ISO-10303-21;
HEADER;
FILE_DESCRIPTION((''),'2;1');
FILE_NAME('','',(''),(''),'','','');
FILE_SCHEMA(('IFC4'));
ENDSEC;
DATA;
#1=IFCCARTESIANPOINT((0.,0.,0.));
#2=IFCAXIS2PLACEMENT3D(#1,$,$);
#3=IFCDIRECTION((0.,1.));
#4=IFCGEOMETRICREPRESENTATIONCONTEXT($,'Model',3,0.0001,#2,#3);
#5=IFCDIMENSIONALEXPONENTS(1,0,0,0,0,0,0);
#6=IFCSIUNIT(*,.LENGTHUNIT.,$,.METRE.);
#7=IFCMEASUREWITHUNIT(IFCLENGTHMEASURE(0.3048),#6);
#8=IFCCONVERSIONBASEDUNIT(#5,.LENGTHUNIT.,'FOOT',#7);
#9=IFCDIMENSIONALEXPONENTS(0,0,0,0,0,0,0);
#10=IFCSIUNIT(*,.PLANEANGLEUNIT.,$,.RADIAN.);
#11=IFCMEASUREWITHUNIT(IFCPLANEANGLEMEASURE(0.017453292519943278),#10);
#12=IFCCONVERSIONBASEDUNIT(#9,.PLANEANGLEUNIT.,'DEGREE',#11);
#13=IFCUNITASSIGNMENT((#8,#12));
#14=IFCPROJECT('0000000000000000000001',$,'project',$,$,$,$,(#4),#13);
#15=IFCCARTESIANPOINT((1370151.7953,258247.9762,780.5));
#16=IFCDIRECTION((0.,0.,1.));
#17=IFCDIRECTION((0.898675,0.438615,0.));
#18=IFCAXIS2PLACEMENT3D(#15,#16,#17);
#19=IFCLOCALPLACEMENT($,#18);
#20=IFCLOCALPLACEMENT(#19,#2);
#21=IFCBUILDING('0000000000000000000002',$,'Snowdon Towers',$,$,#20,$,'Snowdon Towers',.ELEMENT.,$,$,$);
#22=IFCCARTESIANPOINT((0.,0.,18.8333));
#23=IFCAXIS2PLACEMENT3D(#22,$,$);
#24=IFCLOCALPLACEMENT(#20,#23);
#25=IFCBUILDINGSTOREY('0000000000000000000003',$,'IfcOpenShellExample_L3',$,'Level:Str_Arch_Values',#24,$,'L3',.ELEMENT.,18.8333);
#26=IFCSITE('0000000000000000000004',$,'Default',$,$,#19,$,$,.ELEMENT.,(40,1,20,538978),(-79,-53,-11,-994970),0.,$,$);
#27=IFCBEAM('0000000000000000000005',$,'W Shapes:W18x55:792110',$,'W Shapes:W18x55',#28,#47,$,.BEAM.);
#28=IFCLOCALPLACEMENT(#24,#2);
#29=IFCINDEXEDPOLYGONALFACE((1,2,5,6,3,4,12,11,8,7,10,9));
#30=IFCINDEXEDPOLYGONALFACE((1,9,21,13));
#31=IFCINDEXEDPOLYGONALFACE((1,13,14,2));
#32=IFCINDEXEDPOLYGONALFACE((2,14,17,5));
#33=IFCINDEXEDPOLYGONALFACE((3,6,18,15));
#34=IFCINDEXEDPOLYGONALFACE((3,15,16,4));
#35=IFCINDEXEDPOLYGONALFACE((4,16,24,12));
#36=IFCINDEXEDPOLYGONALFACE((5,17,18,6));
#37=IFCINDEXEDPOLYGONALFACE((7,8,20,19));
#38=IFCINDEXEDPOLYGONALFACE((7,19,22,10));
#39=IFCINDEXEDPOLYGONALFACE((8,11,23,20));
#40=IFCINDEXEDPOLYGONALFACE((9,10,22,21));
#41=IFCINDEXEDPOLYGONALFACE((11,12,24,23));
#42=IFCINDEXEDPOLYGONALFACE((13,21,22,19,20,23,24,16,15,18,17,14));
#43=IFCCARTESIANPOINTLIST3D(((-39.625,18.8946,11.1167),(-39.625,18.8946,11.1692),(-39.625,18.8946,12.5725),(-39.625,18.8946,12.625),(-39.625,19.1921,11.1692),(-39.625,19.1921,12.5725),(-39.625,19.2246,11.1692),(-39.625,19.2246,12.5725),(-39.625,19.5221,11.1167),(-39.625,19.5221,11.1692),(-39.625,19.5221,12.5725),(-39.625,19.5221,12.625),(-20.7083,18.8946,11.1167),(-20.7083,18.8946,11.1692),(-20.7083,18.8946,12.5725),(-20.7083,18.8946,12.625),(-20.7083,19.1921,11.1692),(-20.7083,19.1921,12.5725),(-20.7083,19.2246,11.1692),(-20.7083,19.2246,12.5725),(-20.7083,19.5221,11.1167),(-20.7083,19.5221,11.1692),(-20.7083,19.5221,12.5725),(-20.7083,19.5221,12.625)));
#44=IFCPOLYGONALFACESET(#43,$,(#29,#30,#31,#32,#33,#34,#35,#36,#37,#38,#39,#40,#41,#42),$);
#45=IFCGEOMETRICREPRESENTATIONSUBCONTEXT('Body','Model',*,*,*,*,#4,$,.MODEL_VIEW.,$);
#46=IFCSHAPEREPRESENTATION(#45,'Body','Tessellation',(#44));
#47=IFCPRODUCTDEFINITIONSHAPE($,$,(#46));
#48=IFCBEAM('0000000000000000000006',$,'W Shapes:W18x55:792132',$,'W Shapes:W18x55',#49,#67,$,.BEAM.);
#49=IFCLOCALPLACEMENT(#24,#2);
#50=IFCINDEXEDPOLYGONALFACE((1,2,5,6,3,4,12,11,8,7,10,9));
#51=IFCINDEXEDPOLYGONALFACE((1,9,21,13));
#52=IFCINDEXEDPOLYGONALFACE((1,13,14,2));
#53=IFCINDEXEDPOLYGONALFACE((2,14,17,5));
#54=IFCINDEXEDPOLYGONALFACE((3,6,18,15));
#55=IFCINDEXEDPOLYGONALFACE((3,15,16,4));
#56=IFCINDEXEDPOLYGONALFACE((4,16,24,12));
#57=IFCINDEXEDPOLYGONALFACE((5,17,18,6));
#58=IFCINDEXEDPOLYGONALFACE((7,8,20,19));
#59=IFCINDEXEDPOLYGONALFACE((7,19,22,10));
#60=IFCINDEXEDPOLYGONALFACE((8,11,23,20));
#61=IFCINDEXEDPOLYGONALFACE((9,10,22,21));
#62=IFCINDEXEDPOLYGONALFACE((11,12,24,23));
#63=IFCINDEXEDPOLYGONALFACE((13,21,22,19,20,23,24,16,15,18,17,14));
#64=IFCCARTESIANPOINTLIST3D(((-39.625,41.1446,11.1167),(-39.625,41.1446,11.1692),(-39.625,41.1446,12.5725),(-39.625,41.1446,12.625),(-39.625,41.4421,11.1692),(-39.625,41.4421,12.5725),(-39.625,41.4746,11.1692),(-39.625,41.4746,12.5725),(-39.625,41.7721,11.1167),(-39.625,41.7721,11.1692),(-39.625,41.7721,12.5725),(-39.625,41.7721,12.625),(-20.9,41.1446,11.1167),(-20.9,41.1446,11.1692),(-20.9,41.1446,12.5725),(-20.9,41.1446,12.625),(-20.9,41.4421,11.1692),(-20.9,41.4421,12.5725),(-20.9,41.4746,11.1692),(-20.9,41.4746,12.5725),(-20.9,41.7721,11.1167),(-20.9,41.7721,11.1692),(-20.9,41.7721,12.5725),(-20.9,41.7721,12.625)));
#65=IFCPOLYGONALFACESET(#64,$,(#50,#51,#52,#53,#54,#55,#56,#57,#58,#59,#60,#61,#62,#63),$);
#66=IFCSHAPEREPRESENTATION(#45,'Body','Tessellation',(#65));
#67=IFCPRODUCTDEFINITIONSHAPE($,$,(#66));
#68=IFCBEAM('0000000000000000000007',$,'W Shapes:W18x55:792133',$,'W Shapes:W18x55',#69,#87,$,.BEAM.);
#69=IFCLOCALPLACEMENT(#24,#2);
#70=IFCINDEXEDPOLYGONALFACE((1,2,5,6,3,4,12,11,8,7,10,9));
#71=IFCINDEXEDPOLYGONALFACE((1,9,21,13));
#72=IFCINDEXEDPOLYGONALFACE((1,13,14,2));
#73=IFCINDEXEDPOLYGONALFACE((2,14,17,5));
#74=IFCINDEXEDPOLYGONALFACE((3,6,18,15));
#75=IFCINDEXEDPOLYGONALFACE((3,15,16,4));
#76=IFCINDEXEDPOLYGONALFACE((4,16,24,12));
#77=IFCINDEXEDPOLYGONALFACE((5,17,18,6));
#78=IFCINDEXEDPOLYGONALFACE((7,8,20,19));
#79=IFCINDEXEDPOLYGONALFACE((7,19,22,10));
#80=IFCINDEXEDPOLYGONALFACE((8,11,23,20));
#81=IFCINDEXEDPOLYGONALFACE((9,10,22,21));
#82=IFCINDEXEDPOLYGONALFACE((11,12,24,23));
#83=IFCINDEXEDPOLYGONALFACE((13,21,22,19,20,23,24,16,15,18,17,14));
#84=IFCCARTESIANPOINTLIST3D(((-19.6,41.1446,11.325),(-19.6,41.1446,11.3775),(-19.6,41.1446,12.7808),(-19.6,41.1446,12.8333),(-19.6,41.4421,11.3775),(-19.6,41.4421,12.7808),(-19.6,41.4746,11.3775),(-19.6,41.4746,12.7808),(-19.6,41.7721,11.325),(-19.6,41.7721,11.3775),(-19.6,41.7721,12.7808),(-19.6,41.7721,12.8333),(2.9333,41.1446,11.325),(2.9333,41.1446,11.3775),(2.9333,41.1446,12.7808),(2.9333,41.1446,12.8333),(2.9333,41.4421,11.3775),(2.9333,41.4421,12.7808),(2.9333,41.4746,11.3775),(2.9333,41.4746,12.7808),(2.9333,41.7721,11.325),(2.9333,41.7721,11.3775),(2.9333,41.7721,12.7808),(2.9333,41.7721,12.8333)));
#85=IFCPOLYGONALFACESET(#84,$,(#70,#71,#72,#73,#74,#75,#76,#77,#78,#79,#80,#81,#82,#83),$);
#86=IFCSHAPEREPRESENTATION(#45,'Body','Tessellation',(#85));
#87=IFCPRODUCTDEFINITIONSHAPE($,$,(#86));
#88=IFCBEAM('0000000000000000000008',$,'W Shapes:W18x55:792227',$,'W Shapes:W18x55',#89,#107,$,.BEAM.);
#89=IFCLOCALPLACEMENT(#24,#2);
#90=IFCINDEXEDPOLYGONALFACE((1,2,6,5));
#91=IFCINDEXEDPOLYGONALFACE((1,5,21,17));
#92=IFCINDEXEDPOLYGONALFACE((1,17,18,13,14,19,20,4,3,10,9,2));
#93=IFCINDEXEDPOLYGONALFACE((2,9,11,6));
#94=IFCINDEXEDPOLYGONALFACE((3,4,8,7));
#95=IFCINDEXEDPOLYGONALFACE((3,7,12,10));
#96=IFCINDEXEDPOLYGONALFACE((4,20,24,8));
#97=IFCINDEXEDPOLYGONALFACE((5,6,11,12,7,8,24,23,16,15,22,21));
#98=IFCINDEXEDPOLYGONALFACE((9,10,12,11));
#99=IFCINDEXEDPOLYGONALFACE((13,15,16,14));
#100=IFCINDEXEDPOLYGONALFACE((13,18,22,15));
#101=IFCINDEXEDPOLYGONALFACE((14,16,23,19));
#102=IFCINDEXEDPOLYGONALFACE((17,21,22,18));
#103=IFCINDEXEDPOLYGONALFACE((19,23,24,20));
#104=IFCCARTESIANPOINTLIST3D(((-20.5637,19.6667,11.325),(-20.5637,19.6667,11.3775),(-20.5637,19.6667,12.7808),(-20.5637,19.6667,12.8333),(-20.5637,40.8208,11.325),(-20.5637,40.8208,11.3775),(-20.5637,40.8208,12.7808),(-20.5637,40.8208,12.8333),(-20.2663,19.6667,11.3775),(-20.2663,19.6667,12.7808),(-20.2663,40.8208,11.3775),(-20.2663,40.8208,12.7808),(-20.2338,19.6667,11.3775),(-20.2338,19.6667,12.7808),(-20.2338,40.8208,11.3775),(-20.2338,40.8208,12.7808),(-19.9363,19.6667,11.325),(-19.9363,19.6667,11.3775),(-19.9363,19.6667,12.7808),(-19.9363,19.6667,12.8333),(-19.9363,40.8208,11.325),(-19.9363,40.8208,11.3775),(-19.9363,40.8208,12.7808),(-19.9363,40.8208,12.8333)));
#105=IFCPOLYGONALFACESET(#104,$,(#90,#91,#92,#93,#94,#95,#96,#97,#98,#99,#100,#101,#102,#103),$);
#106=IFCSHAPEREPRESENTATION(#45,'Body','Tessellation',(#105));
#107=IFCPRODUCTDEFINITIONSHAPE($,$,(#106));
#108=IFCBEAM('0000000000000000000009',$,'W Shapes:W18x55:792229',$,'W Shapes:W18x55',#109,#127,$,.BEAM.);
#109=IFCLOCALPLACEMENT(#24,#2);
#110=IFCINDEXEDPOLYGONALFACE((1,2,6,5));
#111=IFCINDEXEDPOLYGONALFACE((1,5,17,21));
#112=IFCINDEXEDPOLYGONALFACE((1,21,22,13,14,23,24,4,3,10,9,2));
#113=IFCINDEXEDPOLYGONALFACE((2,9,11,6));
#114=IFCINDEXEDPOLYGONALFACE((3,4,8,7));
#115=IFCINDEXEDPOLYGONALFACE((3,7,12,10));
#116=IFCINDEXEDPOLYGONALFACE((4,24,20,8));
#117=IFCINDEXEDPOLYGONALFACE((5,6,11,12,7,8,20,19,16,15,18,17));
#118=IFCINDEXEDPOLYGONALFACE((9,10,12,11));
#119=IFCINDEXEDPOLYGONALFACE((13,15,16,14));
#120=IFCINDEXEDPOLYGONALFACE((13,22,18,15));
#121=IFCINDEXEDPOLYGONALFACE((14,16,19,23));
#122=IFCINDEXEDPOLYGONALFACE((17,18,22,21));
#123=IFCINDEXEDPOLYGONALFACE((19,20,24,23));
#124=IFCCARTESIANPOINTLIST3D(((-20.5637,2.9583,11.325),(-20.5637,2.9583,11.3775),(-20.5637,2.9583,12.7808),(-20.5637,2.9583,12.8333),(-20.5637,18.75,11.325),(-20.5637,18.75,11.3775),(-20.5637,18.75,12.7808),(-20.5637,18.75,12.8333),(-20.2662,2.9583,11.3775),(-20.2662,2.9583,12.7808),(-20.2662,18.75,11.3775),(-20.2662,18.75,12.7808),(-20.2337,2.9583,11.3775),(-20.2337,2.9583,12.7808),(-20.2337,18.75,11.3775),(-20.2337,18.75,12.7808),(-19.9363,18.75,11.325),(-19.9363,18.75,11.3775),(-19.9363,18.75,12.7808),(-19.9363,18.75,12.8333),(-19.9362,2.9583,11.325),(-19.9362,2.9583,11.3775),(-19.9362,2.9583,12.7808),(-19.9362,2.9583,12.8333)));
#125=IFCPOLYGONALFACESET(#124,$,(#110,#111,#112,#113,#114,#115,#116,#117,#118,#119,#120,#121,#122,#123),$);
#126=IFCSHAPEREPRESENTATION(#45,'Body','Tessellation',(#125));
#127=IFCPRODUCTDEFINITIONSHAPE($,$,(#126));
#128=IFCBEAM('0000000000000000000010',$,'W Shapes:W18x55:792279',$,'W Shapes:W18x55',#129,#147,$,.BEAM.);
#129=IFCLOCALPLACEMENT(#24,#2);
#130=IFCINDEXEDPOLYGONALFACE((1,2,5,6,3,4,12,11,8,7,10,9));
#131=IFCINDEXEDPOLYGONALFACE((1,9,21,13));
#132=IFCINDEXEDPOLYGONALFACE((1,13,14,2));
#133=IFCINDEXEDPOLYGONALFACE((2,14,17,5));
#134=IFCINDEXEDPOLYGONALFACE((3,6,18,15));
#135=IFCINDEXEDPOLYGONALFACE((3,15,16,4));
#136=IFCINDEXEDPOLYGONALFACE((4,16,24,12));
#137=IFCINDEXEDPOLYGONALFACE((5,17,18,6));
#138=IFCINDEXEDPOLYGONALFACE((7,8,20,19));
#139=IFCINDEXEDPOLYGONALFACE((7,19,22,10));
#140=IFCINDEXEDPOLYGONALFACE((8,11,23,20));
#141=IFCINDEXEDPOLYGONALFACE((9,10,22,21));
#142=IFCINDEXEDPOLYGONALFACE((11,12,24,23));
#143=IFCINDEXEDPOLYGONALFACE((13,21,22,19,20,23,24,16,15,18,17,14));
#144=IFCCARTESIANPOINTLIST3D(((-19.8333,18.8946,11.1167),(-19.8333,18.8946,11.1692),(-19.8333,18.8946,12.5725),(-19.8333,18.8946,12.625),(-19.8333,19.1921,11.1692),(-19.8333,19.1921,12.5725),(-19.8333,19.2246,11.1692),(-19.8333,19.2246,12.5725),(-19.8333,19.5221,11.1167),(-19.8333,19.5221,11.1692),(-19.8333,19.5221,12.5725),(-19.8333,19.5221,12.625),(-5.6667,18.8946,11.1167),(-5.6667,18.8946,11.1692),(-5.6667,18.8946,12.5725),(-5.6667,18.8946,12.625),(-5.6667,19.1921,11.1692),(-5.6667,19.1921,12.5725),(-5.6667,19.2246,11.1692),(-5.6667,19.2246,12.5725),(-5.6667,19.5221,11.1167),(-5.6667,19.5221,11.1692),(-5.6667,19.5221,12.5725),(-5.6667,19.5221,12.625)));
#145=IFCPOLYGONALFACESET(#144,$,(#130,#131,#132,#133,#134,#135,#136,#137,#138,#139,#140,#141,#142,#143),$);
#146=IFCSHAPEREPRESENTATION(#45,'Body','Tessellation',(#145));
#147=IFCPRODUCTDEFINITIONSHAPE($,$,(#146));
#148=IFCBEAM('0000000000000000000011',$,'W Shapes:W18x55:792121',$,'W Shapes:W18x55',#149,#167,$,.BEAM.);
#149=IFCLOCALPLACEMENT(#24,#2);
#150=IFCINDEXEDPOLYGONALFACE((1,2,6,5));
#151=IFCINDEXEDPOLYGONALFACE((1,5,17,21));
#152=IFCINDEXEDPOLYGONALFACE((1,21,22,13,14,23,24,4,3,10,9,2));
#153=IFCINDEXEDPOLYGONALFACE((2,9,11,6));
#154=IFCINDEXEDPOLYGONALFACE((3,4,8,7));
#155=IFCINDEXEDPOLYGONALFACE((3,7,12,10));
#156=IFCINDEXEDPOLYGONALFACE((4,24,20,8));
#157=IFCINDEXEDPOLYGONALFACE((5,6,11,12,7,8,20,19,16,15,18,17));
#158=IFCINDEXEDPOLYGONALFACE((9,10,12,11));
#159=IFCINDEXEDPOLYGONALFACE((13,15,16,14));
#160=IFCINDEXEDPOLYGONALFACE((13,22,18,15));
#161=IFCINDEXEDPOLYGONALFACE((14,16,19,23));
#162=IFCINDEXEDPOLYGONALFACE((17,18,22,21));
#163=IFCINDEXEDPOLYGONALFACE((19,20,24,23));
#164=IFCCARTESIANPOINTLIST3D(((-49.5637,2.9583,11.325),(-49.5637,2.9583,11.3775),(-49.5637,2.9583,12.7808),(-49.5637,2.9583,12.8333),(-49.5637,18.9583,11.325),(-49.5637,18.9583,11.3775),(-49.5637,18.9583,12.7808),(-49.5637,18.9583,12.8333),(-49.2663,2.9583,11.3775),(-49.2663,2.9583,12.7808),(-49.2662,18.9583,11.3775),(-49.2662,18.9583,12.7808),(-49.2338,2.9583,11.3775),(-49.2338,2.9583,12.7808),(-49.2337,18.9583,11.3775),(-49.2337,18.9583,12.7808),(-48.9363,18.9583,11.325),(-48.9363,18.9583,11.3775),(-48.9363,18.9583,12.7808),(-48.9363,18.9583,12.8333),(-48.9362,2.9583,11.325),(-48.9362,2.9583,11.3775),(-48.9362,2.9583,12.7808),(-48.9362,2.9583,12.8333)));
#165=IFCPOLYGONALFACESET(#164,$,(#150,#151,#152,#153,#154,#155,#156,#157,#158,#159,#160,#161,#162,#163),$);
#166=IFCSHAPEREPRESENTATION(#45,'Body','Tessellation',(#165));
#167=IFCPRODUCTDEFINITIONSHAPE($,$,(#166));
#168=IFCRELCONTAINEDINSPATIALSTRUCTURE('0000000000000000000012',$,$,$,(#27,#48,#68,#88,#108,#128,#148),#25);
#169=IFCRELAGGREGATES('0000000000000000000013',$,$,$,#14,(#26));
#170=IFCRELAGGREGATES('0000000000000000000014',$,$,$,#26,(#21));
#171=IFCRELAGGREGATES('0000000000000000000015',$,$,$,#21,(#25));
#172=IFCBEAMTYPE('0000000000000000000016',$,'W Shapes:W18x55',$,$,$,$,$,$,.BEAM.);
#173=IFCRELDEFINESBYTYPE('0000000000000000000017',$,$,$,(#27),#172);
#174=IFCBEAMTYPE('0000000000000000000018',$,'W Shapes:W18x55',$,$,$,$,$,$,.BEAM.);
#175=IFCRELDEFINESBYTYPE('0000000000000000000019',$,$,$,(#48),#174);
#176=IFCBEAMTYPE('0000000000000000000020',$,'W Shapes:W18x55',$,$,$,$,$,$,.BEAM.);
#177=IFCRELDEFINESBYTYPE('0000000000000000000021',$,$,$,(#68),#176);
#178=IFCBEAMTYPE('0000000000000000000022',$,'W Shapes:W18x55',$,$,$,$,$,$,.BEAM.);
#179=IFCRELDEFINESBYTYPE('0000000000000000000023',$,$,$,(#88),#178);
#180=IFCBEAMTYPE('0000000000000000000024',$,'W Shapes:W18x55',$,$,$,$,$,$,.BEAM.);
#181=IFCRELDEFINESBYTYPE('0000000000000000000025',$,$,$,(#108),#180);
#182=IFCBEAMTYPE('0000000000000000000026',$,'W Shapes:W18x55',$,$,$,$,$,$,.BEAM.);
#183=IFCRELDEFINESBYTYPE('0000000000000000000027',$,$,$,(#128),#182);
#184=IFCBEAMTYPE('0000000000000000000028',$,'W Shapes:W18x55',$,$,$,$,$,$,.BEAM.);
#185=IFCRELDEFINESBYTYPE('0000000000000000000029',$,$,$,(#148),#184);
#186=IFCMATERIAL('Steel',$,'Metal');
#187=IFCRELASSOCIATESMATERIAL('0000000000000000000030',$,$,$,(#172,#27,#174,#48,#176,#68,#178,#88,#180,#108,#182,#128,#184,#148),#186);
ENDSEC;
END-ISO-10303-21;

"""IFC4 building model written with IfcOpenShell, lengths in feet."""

from ifc_helpers import new_model, entity, si_unit, converted_unit, direction, frame, origin, place, context, subcontext, project, spatial, indexed_curve, outline, extrude, source, transform, mapped, material, type_object, type_shapes, element, save


model = new_model("IFC4")

# Units and contexts
model_context = context("Model", 3, precision=0.0001, world=origin(), true_north=direction((0.0, 1.0)))
body_context = subcontext(model_context, "Body", "Model", "MODEL_VIEW")
ifc_project = project(units=[converted_unit("LENGTHUNIT", "FOOT", entity("IfcLengthMeasure", 0.3048), si_unit("LENGTHUNIT", "METRE"), dimensions=[1, 0, 0, 0, 0, 0, 0]), converted_unit("PLANEANGLEUNIT", "DEGREE", entity("IfcPlaneAngleMeasure", 0.017453292519943278), si_unit("PLANEANGLEUNIT", "RADIAN"), dimensions=[0, 0, 0, 0, 0, 0, 0])], contexts=[model_context])

# Site, building, storey
site_placement = place(None, frame((1370151.7953, 258247.9762, 780.5), z_axis=(0.0, 0.0, 1.0), x_axis=(0.898675, 0.438615, 0.0)))
site = spatial("IfcSite", under=ifc_project, at=site_placement, Name="Default", CompositionType="ELEMENT", RefLatitude=(40, 1, 20, 538978), RefLongitude=(-79, -53, -11, -994970), RefElevation=0.0)
building_placement = place(site_placement, origin())
building = spatial("IfcBuilding", under=site, at=building_placement, Name="Snowdon Towers", LongName="Snowdon Towers", CompositionType="ELEMENT")
storey_placement = place(building_placement, frame((0.0, 0.0, 18.8333)))
storey = spatial("IfcBuildingStorey", under=building, at=storey_placement, Name="IfcOpenShellExample_L3", ObjectType="Level:Str_Arch_Values", LongName="L3", CompositionType="ELEMENT", Elevation=18.8333)

# Shared definitions
ifc_material = material(Name="Steel", Category="Metal")

# Beams
beam_type_1 = type_object("IfcBeamType", Name="W Shapes:W18x55", PredefinedType="BEAM", material=ifc_material)
shared_shape_1 = source(origin(), body_context, "Body", "SweptSolid", [
    extrude(outline(indexed_curve([(-0.3138, -0.7017), (-0.3138, -0.7542), (0.3138, -0.7542), (0.3138, -0.7017), (0.0162, -0.7017), (0.0162, 0.7017), (0.3138, 0.7017), (0.3138, 0.7542), (-0.3137, 0.7542), (-0.3137, 0.7017), (-0.0163, 0.7017), (-0.0163, -0.7017), (-0.3138, -0.7017)], self_intersect=False)), frame((-9.5625, 0.0, 0.0), z_axis=(-1.0, 0.0, 0.0), x_axis=(0.0, -1.0, 0.0)), (0.0, 0.0, -1.0), 18.9167),
])
type_shapes(beam_type_1, [shared_shape_1])
beam_1_placement = place(storey_placement, frame((-30.0625, 19.2083, 11.8708)))
element("IfcBeam", 1, at=beam_1_placement, inside=storey, type_object=beam_type_1, material=ifc_material, Name="W Shapes:W18x55:792110", ObjectType="W Shapes:W18x55", PredefinedType="BEAM", context=body_context, shape_type="MappedRepresentation", body=[
    mapped(shared_shape_1, transform((0.0, 0.0, 0.0), scale=1.0)),
])
beam_type_2 = type_object("IfcBeamType", Name="W Shapes:W18x55", PredefinedType="BEAM", material=ifc_material)
shared_shape_2 = source(origin(), body_context, "Body", "SweptSolid", [
    extrude(outline(indexed_curve([(-0.3138, -0.7017), (-0.3138, -0.7542), (0.3138, -0.7542), (0.3138, -0.7017), (0.0162, -0.7017), (0.0162, 0.7017), (0.3138, 0.7017), (0.3138, 0.7542), (-0.3137, 0.7542), (-0.3137, 0.7017), (-0.0163, 0.7017), (-0.0163, -0.7017), (-0.3138, -0.7017)], self_intersect=False)), frame((-9.5625, 0.0, 0.0), z_axis=(-1.0, 0.0, 0.0), x_axis=(0.0, -1.0, 0.0)), (0.0, 0.0, -1.0), 18.725),
])
type_shapes(beam_type_2, [shared_shape_2])
beam_2_placement = place(storey_placement, frame((-30.0625, 41.4583, 11.8708)))
element("IfcBeam", 2, at=beam_2_placement, inside=storey, type_object=beam_type_2, material=ifc_material, Name="W Shapes:W18x55:792132", ObjectType="W Shapes:W18x55", PredefinedType="BEAM", context=body_context, shape_type="MappedRepresentation", body=[
    mapped(shared_shape_2, transform((0.0, 0.0, 0.0), scale=1.0)),
])
beam_type_3 = type_object("IfcBeamType", Name="W Shapes:W18x55", PredefinedType="BEAM", material=ifc_material)
shared_shape_3 = source(origin(), body_context, "Body", "SweptSolid", [
    extrude(outline(indexed_curve([(-0.3138, -0.7017), (-0.3138, -0.7542), (0.3138, -0.7542), (0.3138, -0.7017), (0.0162, -0.7017), (0.0162, 0.7017), (0.3138, 0.7017), (0.3138, 0.7542), (-0.3137, 0.7542), (-0.3137, 0.7017), (-0.0163, 0.7017), (-0.0163, -0.7017), (-0.3138, -0.7017)], self_intersect=False)), frame((-11.35, 0.0, 0.0), z_axis=(-1.0, 0.0, 0.0), x_axis=(0.0, -1.0, 0.0)), (0.0, 0.0, -1.0), 22.5333),
])
type_shapes(beam_type_3, [shared_shape_3])
beam_3_placement = place(storey_placement, frame((-8.25, 41.4583, 12.0792)))
element("IfcBeam", 3, at=beam_3_placement, inside=storey, type_object=beam_type_3, material=ifc_material, Name="W Shapes:W18x55:792133", ObjectType="W Shapes:W18x55", PredefinedType="BEAM", context=body_context, shape_type="MappedRepresentation", body=[
    mapped(shared_shape_3, transform((0.0, 0.0, 0.0), scale=1.0)),
])
beam_type_4 = type_object("IfcBeamType", Name="W Shapes:W18x55", PredefinedType="BEAM", material=ifc_material)
shared_shape_4 = source(origin(), body_context, "Body", "SweptSolid", [
    extrude(outline(indexed_curve([(-0.3138, -0.7017), (-0.3138, -0.7542), (0.3138, -0.7542), (0.3138, -0.7017), (0.0162, -0.7017), (0.0162, 0.7017), (0.3138, 0.7017), (0.3138, 0.7542), (-0.3137, 0.7542), (-0.3137, 0.7017), (-0.0163, 0.7017), (-0.0163, -0.7017), (-0.3138, -0.7017)], self_intersect=False)), frame((-10.4042, 0.0, 0.0), z_axis=(-1.0, 0.0, 0.0), x_axis=(0.0, -1.0, 0.0)), (0.0, 0.0, -1.0), 21.1542),
])
type_shapes(beam_type_4, [shared_shape_4])
beam_4_placement = place(storey_placement, frame((-20.25, 30.4167, 12.0792), z_axis=(0.0, 0.0, 1.0), x_axis=(0.0, -1.0, 0.0)))
element("IfcBeam", 4, at=beam_4_placement, inside=storey, type_object=beam_type_4, material=ifc_material, Name="W Shapes:W18x55:792227", ObjectType="W Shapes:W18x55", PredefinedType="BEAM", context=body_context, shape_type="MappedRepresentation", body=[
    mapped(shared_shape_4, transform((0.0, 0.0, 0.0), scale=1.0)),
])
beam_type_5 = type_object("IfcBeamType", Name="W Shapes:W18x55", PredefinedType="BEAM", material=ifc_material)
shared_shape_5 = source(origin(), body_context, "Body", "SweptSolid", [
    extrude(outline(indexed_curve([(-0.3138, -0.7017), (-0.3138, -0.7542), (0.3138, -0.7542), (0.3138, -0.7017), (0.0162, -0.7017), (0.0162, 0.7017), (0.3138, 0.7017), (0.3138, 0.7542), (-0.3137, 0.7542), (-0.3137, 0.7017), (-0.0163, 0.7017), (-0.0163, -0.7017), (-0.3138, -0.7017)], self_intersect=False)), frame((-7.8958, 0.0, 0.0), z_axis=(-1.0, 0.0, 0.0), x_axis=(0.0, -1.0, 0.0)), (0.0, 0.0, -1.0), 15.7917),
])
type_shapes(beam_type_5, [shared_shape_5])
beam_5_placement = place(storey_placement, frame((-20.25, 10.8542, 12.0792), z_axis=(0.0, 0.0, 1.0), x_axis=(0.0, -1.0, 0.0)))
element("IfcBeam", 5, at=beam_5_placement, inside=storey, type_object=beam_type_5, material=ifc_material, Name="W Shapes:W18x55:792229", ObjectType="W Shapes:W18x55", PredefinedType="BEAM", context=body_context, shape_type="MappedRepresentation", body=[
    mapped(shared_shape_5, transform((0.0, 0.0, 0.0), scale=1.0)),
])
beam_type_6 = type_object("IfcBeamType", Name="W Shapes:W18x55", PredefinedType="BEAM", material=ifc_material)
shared_shape_6 = source(origin(), body_context, "Body", "SweptSolid", [
    extrude(outline(indexed_curve([(-0.3138, -0.7017), (-0.3138, -0.7542), (0.3138, -0.7542), (0.3138, -0.7017), (0.0162, -0.7017), (0.0162, 0.7017), (0.3138, 0.7017), (0.3138, 0.7542), (-0.3137, 0.7542), (-0.3137, 0.7017), (-0.0163, 0.7017), (-0.0163, -0.7017), (-0.3138, -0.7017)], self_intersect=False)), frame((-7.2917, 0.0, 0.0), z_axis=(-1.0, 0.0, 0.0), x_axis=(0.0, -1.0, 0.0)), (0.0, 0.0, -1.0), 14.1667),
])
type_shapes(beam_type_6, [shared_shape_6])
beam_6_placement = place(storey_placement, frame((-12.9583, 19.2083, 11.8708), z_axis=(0.0, 0.0, 1.0), x_axis=(-1.0, 0.0, 0.0)))
element("IfcBeam", 6, at=beam_6_placement, inside=storey, type_object=beam_type_6, material=ifc_material, Name="W Shapes:W18x55:792279", ObjectType="W Shapes:W18x55", PredefinedType="BEAM", context=body_context, shape_type="MappedRepresentation", body=[
    mapped(shared_shape_6, transform((0.0, 0.0, 0.0), scale=1.0)),
])

# Beam
beam_type_7 = type_object("IfcBeamType", Name="W Shapes:W18x55", PredefinedType="BEAM", material=ifc_material)
shared_shape_7 = source(origin(), body_context, "Body", "SweptSolid", [
    extrude(outline(indexed_curve([(-0.3138, -0.7017), (-0.3138, -0.7542), (0.3138, -0.7542), (0.3138, -0.7017), (0.0162, -0.7017), (0.0162, 0.7017), (0.3138, 0.7017), (0.3138, 0.7542), (-0.3137, 0.7542), (-0.3137, 0.7017), (-0.0163, 0.7017), (-0.0163, -0.7017), (-0.3138, -0.7017)], self_intersect=False)), frame((-8.1042, 0.0, 0.0), z_axis=(-1.0, 0.0, 0.0), x_axis=(0.0, -1.0, 0.0)), (0.0, 0.0, -1.0), 16.0),
])
type_shapes(beam_type_7, [shared_shape_7])
beam_7_placement = place(storey_placement, frame((-49.25, 10.8542, 12.0792), z_axis=(0.0, 0.0, 1.0), x_axis=(0.0, -1.0, 0.0)))
element("IfcBeam", 7, at=beam_7_placement, inside=storey, type_object=beam_type_7, material=ifc_material, Name="W Shapes:W18x55:792121", ObjectType="W Shapes:W18x55", PredefinedType="BEAM", context=body_context, shape_type="MappedRepresentation", body=[
    mapped(shared_shape_7, transform((0.0, 0.0, 0.0), scale=1.0)),
])

save(model, "model.ifc")
